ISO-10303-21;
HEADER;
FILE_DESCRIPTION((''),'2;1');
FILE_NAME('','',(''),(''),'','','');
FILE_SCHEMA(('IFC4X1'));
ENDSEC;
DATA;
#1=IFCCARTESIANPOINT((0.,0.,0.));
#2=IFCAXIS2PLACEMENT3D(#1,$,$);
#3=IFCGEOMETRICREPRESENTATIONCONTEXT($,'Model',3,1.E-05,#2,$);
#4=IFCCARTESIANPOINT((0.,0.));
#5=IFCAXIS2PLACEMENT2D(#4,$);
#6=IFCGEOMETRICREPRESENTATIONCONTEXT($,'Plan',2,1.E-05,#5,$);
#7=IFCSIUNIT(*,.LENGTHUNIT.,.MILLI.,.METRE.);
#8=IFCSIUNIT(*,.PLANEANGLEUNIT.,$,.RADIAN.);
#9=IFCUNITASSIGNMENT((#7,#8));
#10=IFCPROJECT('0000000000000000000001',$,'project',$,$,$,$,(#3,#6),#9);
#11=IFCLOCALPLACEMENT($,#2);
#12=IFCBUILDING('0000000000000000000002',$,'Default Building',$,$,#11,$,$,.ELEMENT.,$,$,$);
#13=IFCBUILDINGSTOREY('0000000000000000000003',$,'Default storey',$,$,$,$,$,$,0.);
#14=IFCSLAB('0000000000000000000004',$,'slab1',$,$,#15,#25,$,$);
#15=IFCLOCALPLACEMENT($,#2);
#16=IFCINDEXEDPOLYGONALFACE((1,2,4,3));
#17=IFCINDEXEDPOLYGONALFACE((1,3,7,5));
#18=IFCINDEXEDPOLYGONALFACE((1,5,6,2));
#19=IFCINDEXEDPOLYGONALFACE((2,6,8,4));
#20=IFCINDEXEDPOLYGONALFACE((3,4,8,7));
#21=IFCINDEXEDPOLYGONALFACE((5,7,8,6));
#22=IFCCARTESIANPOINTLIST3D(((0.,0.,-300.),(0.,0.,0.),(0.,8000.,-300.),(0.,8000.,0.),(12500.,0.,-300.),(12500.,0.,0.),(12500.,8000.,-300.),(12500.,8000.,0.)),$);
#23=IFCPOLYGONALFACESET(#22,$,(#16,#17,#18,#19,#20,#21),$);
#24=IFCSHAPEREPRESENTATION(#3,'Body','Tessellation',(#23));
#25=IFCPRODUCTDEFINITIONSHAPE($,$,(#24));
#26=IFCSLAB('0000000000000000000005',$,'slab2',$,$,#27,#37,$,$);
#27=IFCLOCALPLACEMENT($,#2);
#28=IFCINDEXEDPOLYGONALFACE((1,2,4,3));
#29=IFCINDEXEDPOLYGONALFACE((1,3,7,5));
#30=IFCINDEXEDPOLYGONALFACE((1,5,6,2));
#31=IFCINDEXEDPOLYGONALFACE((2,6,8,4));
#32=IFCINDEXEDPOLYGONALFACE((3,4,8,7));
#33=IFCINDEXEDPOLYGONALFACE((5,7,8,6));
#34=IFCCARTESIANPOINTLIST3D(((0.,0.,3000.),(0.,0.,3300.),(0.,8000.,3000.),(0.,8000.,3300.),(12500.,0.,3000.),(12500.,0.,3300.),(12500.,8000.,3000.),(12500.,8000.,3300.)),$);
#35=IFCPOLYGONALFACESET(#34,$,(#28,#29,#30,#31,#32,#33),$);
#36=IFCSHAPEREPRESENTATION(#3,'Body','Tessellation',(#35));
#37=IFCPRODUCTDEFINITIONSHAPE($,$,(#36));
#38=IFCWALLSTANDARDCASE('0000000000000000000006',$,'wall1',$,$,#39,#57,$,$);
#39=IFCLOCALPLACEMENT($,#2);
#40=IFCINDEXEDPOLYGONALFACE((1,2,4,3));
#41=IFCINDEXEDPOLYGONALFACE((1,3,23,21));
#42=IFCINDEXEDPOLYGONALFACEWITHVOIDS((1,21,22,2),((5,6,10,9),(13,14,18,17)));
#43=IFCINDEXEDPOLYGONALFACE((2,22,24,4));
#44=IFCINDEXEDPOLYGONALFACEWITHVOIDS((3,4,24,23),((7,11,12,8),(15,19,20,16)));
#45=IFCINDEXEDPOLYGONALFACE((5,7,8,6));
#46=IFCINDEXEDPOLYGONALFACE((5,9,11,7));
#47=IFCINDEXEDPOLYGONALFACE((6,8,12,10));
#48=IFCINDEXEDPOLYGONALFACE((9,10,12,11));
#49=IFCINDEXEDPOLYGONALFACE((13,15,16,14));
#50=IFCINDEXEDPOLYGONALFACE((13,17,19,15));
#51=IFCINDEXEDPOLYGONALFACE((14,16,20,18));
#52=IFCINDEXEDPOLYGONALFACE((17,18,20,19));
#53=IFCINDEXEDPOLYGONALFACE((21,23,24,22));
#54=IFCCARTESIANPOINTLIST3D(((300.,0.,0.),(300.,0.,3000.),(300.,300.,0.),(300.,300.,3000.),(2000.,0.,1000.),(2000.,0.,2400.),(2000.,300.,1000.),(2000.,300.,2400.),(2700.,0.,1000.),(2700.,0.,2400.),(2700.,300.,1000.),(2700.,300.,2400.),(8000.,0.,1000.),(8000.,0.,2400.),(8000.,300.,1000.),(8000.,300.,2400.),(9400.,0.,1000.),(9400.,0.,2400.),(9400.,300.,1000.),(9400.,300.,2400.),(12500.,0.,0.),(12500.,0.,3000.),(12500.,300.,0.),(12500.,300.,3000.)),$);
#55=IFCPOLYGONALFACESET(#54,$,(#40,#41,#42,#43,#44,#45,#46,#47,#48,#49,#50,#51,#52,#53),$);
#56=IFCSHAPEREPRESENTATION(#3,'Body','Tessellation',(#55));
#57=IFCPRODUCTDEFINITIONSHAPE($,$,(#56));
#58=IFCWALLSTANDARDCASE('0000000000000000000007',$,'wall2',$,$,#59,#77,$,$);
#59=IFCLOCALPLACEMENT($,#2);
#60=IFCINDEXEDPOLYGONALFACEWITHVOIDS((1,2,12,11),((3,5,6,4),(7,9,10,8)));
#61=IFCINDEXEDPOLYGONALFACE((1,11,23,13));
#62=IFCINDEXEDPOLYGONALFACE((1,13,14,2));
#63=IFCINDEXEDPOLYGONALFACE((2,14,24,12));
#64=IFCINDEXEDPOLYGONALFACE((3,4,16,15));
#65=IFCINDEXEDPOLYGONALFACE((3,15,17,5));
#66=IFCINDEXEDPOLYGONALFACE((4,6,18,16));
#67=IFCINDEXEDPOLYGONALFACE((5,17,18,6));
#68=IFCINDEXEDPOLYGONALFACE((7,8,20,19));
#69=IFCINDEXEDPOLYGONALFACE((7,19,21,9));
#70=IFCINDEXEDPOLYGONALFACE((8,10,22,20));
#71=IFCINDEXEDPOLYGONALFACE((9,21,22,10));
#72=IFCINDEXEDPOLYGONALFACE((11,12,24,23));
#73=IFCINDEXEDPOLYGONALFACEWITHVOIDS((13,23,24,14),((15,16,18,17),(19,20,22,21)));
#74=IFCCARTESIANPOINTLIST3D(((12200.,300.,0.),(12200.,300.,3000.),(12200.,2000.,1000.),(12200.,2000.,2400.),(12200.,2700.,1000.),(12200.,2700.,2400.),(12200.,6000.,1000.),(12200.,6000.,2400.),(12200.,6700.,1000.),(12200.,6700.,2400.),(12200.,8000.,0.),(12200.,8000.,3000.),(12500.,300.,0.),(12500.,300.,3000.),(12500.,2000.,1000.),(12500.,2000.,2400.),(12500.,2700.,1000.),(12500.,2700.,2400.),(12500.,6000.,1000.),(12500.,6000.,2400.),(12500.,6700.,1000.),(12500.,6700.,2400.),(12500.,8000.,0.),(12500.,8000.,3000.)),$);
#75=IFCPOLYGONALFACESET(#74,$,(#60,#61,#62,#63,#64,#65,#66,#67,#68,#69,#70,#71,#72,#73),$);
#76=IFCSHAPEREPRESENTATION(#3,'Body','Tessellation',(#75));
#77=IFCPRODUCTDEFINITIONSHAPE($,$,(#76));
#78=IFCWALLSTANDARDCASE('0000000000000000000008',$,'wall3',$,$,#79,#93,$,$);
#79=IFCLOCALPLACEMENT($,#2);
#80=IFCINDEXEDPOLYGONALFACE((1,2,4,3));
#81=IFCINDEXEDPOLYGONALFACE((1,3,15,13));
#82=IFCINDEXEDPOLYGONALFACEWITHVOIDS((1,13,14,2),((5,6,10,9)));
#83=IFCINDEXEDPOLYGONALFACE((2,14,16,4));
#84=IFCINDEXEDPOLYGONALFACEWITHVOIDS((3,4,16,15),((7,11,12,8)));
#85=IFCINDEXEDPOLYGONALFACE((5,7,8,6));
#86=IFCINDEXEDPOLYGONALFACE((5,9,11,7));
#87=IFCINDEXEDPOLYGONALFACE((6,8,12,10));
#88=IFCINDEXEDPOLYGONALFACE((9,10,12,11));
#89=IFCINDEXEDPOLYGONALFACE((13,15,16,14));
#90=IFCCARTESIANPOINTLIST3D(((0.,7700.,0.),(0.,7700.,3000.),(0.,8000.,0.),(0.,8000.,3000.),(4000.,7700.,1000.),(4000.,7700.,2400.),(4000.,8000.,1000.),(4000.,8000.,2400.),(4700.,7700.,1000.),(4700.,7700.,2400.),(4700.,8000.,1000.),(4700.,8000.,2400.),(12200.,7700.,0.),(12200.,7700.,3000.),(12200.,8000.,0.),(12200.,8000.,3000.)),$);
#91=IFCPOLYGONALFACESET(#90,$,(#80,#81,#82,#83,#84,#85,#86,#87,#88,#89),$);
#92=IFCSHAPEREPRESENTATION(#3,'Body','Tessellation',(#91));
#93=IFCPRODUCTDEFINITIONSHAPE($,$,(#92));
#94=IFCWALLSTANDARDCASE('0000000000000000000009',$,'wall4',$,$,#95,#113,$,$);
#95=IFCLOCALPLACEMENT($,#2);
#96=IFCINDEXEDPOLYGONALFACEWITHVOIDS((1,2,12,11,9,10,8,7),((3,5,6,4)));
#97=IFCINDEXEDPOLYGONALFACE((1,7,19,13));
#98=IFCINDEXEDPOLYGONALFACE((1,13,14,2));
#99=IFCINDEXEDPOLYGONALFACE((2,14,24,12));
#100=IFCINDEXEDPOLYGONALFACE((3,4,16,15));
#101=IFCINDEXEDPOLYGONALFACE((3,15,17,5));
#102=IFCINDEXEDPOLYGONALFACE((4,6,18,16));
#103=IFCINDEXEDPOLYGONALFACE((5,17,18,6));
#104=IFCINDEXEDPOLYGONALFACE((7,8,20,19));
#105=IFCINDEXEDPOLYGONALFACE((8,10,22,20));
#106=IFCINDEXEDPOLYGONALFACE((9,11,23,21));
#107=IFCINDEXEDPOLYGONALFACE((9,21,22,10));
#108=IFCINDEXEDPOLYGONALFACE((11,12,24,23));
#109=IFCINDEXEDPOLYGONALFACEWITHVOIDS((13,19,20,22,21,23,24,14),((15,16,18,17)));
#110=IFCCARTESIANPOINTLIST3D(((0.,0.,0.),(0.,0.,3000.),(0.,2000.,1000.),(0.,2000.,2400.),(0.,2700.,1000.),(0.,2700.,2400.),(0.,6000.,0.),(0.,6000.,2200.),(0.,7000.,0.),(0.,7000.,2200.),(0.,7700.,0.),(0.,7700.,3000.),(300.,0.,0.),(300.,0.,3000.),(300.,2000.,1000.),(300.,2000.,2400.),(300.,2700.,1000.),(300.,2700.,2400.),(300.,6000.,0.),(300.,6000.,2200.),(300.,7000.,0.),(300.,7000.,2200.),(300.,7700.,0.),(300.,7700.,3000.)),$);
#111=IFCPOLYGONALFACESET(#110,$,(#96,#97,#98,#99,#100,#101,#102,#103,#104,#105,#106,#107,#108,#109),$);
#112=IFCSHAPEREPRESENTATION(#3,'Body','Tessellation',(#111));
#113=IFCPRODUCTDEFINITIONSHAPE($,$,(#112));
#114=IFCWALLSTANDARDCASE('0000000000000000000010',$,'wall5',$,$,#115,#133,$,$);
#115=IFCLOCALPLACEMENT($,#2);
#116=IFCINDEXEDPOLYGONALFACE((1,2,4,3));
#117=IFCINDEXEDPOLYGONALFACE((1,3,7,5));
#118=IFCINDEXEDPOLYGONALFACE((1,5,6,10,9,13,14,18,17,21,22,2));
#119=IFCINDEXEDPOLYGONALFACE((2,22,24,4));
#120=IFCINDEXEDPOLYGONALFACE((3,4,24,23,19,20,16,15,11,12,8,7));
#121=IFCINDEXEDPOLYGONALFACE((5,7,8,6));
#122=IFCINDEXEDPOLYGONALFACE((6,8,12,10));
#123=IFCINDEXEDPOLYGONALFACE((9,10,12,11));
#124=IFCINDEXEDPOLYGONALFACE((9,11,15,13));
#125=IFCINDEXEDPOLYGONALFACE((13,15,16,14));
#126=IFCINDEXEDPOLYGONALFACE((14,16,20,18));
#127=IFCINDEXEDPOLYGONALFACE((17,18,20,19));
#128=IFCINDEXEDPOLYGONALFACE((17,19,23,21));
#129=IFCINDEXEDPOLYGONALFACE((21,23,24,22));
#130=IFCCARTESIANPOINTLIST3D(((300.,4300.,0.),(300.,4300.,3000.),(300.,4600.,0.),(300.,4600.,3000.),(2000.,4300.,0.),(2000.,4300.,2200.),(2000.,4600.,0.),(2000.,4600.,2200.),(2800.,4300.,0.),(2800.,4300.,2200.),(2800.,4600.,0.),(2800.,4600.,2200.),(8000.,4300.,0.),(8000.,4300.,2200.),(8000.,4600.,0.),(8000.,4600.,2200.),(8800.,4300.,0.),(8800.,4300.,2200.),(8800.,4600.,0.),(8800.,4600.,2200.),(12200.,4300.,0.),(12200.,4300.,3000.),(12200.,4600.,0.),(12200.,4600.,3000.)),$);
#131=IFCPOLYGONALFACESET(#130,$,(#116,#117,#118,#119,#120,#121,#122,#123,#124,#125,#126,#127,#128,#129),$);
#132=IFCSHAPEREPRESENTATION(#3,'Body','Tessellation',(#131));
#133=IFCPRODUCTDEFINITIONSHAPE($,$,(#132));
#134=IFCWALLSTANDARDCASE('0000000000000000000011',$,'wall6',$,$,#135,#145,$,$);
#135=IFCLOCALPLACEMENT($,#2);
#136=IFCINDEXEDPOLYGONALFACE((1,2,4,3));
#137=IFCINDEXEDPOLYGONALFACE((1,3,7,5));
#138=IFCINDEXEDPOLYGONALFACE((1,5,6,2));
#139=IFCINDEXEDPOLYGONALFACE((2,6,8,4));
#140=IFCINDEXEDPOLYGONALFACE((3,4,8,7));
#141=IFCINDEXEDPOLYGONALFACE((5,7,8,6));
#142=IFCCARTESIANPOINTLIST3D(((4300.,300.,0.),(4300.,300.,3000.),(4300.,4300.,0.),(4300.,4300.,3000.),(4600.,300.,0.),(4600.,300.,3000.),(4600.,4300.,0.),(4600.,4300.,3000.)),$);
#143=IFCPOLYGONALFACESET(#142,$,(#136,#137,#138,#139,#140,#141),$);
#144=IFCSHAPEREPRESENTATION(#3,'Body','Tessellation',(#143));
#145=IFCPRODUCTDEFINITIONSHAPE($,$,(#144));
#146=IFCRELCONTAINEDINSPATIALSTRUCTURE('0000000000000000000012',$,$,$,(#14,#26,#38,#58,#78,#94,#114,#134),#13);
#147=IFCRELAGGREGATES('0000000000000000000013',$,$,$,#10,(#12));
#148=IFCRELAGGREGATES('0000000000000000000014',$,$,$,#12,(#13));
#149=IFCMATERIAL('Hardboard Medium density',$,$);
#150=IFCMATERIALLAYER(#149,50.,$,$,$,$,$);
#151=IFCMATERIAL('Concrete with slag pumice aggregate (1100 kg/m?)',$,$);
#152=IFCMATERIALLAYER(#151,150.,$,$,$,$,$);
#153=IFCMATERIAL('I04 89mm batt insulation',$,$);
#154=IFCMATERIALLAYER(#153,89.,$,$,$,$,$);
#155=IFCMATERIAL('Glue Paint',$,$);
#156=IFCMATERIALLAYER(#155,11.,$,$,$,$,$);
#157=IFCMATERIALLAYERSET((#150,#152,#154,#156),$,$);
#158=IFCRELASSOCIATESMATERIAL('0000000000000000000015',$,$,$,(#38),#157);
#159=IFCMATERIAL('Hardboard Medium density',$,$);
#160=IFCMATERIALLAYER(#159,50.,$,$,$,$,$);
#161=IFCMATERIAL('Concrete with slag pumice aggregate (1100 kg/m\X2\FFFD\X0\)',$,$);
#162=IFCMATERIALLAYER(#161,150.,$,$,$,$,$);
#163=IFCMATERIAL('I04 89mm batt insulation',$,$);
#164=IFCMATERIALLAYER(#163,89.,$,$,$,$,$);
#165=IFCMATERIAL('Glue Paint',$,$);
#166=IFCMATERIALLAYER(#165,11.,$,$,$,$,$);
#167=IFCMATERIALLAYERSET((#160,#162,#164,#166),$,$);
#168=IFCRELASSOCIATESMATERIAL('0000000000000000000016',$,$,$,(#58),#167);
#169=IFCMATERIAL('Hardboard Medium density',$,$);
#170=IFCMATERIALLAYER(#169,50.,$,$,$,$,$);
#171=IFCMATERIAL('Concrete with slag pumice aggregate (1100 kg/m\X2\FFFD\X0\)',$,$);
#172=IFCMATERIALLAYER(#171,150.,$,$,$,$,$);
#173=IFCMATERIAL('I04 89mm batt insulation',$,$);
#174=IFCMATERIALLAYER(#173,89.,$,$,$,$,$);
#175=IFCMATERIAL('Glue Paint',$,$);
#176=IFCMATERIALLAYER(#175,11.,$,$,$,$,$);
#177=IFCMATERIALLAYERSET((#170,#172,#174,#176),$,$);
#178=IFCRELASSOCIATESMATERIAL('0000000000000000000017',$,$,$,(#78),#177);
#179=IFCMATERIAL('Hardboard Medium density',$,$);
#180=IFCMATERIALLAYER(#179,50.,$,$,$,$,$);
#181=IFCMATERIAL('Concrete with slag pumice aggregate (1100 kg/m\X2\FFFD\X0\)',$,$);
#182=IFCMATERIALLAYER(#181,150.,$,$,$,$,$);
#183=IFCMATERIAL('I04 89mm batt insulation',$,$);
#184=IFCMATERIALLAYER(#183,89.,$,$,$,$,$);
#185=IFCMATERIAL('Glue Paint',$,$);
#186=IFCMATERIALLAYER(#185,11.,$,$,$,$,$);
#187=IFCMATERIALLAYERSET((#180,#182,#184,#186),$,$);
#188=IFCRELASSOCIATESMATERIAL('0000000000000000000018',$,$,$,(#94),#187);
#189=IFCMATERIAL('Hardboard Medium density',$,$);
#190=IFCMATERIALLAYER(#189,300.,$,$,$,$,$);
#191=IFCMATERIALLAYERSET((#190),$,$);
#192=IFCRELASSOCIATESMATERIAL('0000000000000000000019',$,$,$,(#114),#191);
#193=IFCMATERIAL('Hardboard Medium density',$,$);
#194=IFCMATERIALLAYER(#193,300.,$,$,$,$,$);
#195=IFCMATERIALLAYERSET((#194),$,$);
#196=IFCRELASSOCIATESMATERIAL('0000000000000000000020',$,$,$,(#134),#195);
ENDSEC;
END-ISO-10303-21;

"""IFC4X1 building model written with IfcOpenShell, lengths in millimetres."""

from ifc_helpers import new_model, si_unit, frame, origin, origin_2d, place, context, project, spatial, polyline, outline, extrude, material, layer, layer_set, layer_usage, element, save


model = new_model("IFC4X1")

# Units and contexts
model_context = context("Model", 3, precision=1e-05, world=origin())
plan_context = context("Plan", 2, precision=1e-05, world=origin_2d())
ifc_project = project(units=[si_unit("LENGTHUNIT", "METRE", prefix="MILLI"), si_unit("PLANEANGLEUNIT", "RADIAN")], contexts=[model_context, plan_context])

# Building, storey
building_placement = place(None, origin())
building = spatial("IfcBuilding", under=ifc_project, at=building_placement, Name="Default Building", CompositionType="ELEMENT")
storey = spatial("IfcBuildingStorey", under=building, Name="Default storey", Elevation=0.0)

# Slabs
slab_1_placement = place(None, frame((0.0, 0.0, -300.0), z_axis=(0.0, 0.0, 1.0)))
element("IfcSlab", 1, at=slab_1_placement, inside=storey, Name="slab1", context=model_context, shape_type="SweptSolid", body=[
    extrude(outline(polyline([(0.0, 0.0), (12500.0, 0.0), (12500.0, 8000.0), (0.0, 8000.0), (0.0, 0.0)])), origin(), (0.0, 0.0, 1.0), 300.0),
])
slab_2_placement = place(None, frame((0.0, 0.0, 3000.0), z_axis=(0.0, 0.0, 1.0)))
element("IfcSlab", 2, at=slab_2_placement, inside=storey, Name="slab2", context=model_context, shape_type="SweptSolid", body=[
    extrude(outline(polyline([(0.0, 0.0), (0.0, 8000.0), (12500.0, 8000.0), (12500.0, 0.0), (0.0, 0.0)])), origin(), (0.0, 0.0, 1.0), 300.0),
])

# Walls, openings
ifc_material_1 = material(Name="Hardboard Medium density")
ifc_layer_1 = layer(ifc_material_1, 50.0)
ifc_material_2 = material(Name="Concrete with slag pumice aggregate (1100 kg/m?)")
ifc_layer_2 = layer(ifc_material_2, 150.0)
ifc_material_3 = material(Name="I04 89mm batt insulation")
ifc_layer_3 = layer(ifc_material_3, 89.0)
ifc_material_4 = material(Name="Glue Paint")
ifc_layer_4 = layer(ifc_material_4, 11.0)
ifc_layer_set_1 = layer_set([ifc_layer_1, ifc_layer_2, ifc_layer_3, ifc_layer_4])
ifc_layer_usage_1 = layer_usage(ifc_layer_set_1, "AXIS2", "NEGATIVE", 150.0)
wall_1_placement = place(None, frame((0.0, 0.0, 0.0), z_axis=(0.0, 0.0, 1.0)))
wall_1 = element("IfcWallStandardCase", 3, at=wall_1_placement, inside=storey, material=ifc_layer_usage_1, Name="wall1", context=model_context, shape_type="SweptSolid", body=[
    extrude(outline(polyline([(300.0, 0.0), (12500.0, 0.0), (12500.0, 300.0), (300.0, 300.0), (300.0, 0.0)])), origin(), (0.0, 0.0, 1.0), 3000.0),
])
opening_1_placement = place(None, frame((0.0, 0.0, 1000.0), z_axis=(0.0, 0.0, 1.0)))
element("IfcOpeningElement", 4, at=opening_1_placement, inside=storey, cuts=wall_1, context=model_context, shape_type="SweptSolid", body=[
    extrude(outline(polyline([(8000.0, 0.0), (9400.0, 0.0), (9400.0, 300.0), (8000.0, 300.0), (8000.0, 0.0)])), origin(), (0.0, 0.0, 1.0), 1400.0),
])
opening_2_placement = place(None, frame((0.0, 0.0, 1000.0), z_axis=(0.0, 0.0, 1.0)))
element("IfcOpeningElement", 5, at=opening_2_placement, inside=storey, cuts=wall_1, context=model_context, shape_type="SweptSolid", body=[
    extrude(outline(polyline([(2000.0, 0.0), (2700.0, 0.0), (2700.0, 300.0), (2000.0, 300.0), (2000.0, 0.0)])), origin(), (0.0, 0.0, 1.0), 1400.0),
])
ifc_material_5 = material(Name="Hardboard Medium density")
ifc_layer_5 = layer(ifc_material_5, 50.0)
ifc_material_6 = material(Name="Concrete with slag pumice aggregate (1100 kg/m�)")
ifc_layer_6 = layer(ifc_material_6, 150.0)
ifc_material_7 = material(Name="I04 89mm batt insulation")
ifc_layer_7 = layer(ifc_material_7, 89.0)
ifc_material_8 = material(Name="Glue Paint")
ifc_layer_8 = layer(ifc_material_8, 11.0)
ifc_layer_set_2 = layer_set([ifc_layer_5, ifc_layer_6, ifc_layer_7, ifc_layer_8])
ifc_layer_usage_2 = layer_usage(ifc_layer_set_2, "AXIS2", "NEGATIVE", 150.0)
wall_2_placement = place(None, frame((0.0, 0.0, 0.0), z_axis=(0.0, 0.0, 1.0)))
wall_2 = element("IfcWallStandardCase", 6, at=wall_2_placement, inside=storey, material=ifc_layer_usage_2, Name="wall2", context=model_context, shape_type="SweptSolid", body=[
    extrude(outline(polyline([(12500.0, 300.0), (12500.0, 8000.0), (12200.0, 8000.0), (12200.0, 300.0), (12500.0, 300.0)])), origin(), (0.0, 0.0, 1.0), 3000.0),
])
opening_3_placement = place(None, frame((0.0, 0.0, 1000.0), z_axis=(0.0, 0.0, 1.0)))
element("IfcOpeningElement", 7, at=opening_3_placement, inside=storey, cuts=wall_2, context=model_context, shape_type="SweptSolid", body=[
    extrude(outline(polyline([(12500.0, 6000.0), (12500.0, 6700.0), (12200.0, 6700.0), (12200.0, 6000.0), (12500.0, 6000.0)])), origin(), (0.0, 0.0, 1.0), 1400.0),
])
opening_4_placement = place(None, frame((0.0, 0.0, 1000.0), z_axis=(0.0, 0.0, 1.0)))
element("IfcOpeningElement", 8, at=opening_4_placement, inside=storey, cuts=wall_2, context=model_context, shape_type="SweptSolid", body=[
    extrude(outline(polyline([(12500.0, 2000.0), (12500.0, 2700.0), (12200.0, 2700.0), (12200.0, 2000.0), (12500.0, 2000.0)])), origin(), (0.0, 0.0, 1.0), 1400.0),
])

# Wall, opening
ifc_material_9 = material(Name="Hardboard Medium density")
ifc_layer_9 = layer(ifc_material_9, 50.0)
ifc_material_10 = material(Name="Concrete with slag pumice aggregate (1100 kg/m�)")
ifc_layer_10 = layer(ifc_material_10, 150.0)
ifc_material_11 = material(Name="I04 89mm batt insulation")
ifc_layer_11 = layer(ifc_material_11, 89.0)
ifc_material_12 = material(Name="Glue Paint")
ifc_layer_12 = layer(ifc_material_12, 11.0)
ifc_layer_set_3 = layer_set([ifc_layer_9, ifc_layer_10, ifc_layer_11, ifc_layer_12])
ifc_layer_usage_3 = layer_usage(ifc_layer_set_3, "AXIS2", "NEGATIVE", 150.0)
wall_3_placement = place(None, frame((0.0, 0.0, 0.0), z_axis=(0.0, 0.0, 1.0)))
wall_3 = element("IfcWallStandardCase", 9, at=wall_3_placement, inside=storey, material=ifc_layer_usage_3, Name="wall3", context=model_context, shape_type="SweptSolid", body=[
    extrude(outline(polyline([(12200.0, 8000.0), (0.0, 8000.0), (0.0, 7700.0), (12200.0, 7700.0), (12200.0, 8000.0)])), origin(), (0.0, 0.0, 1.0), 3000.0),
])
opening_5_placement = place(None, frame((0.0, 0.0, 1000.0), z_axis=(0.0, 0.0, 1.0)))
element("IfcOpeningElement", 10, at=opening_5_placement, inside=storey, cuts=wall_3, context=model_context, shape_type="SweptSolid", body=[
    extrude(outline(polyline([(4000.0, 8000.0), (4700.0, 8000.0), (4700.0, 7700.0), (4000.0, 7700.0), (4000.0, 8000.0)])), origin(), (0.0, 0.0, 1.0), 1400.0),
])

# Walls, openings
ifc_material_13 = material(Name="Hardboard Medium density")
ifc_layer_13 = layer(ifc_material_13, 50.0)
ifc_material_14 = material(Name="Concrete with slag pumice aggregate (1100 kg/m�)")
ifc_layer_14 = layer(ifc_material_14, 150.0)
ifc_material_15 = material(Name="I04 89mm batt insulation")
ifc_layer_15 = layer(ifc_material_15, 89.0)
ifc_material_16 = material(Name="Glue Paint")
ifc_layer_16 = layer(ifc_material_16, 11.0)
ifc_layer_set_4 = layer_set([ifc_layer_13, ifc_layer_14, ifc_layer_15, ifc_layer_16])
ifc_layer_usage_4 = layer_usage(ifc_layer_set_4, "AXIS2", "NEGATIVE", 150.0)
wall_4_placement = place(None, frame((0.0, 0.0, 0.0), z_axis=(0.0, 0.0, 1.0)))
wall_4 = element("IfcWallStandardCase", 11, at=wall_4_placement, inside=storey, material=ifc_layer_usage_4, Name="wall4", context=model_context, shape_type="SweptSolid", body=[
    extrude(outline(polyline([(0.0, 7700.0), (0.0, 0.0), (300.0, 0.0), (300.0, 7700.0), (0.0, 7700.0)])), origin(), (0.0, 0.0, 1.0), 3000.0),
])
opening_6_placement = place(None, frame((0.0, 0.0, 0.0), z_axis=(0.0, 0.0, 1.0)))
element("IfcOpeningElement", 12, at=opening_6_placement, inside=storey, cuts=wall_4, context=model_context, shape_type="SweptSolid", body=[
    extrude(outline(polyline([(0.0, 6000.0), (0.0, 7000.0), (300.0, 7000.0), (300.0, 6000.0), (0.0, 6000.0)])), origin(), (0.0, 0.0, 1.0), 2200.0),
])
opening_7_placement = place(None, frame((0.0, 0.0, 1000.0), z_axis=(0.0, 0.0, 1.0)))
element("IfcOpeningElement", 13, at=opening_7_placement, inside=storey, cuts=wall_4, context=model_context, shape_type="SweptSolid", body=[
    extrude(outline(polyline([(0.0, 2000.0), (0.0, 2700.0), (300.0, 2700.0), (300.0, 2000.0), (0.0, 2000.0)])), origin(), (0.0, 0.0, 1.0), 1400.0),
])
ifc_material_17 = material(Name="Hardboard Medium density")
ifc_layer_17 = layer(ifc_material_17, 300.0)
ifc_layer_set_5 = layer_set([ifc_layer_17])
ifc_layer_usage_5 = layer_usage(ifc_layer_set_5, "AXIS2", "NEGATIVE", 150.0)
wall_5_placement = place(None, frame((0.0, 0.0, 0.0), z_axis=(0.0, 0.0, 1.0)))
wall_5 = element("IfcWallStandardCase", 14, at=wall_5_placement, inside=storey, material=ifc_layer_usage_5, Name="wall5", context=model_context, shape_type="SweptSolid", body=[
    extrude(outline(polyline([(12200.0, 4600.0), (300.0, 4600.0), (300.0, 4300.0), (12200.0, 4300.0), (12200.0, 4600.0)])), origin(), (0.0, 0.0, 1.0), 3000.0),
])
opening_8_placement = place(None, frame((0.0, 0.0, 0.0), z_axis=(0.0, 0.0, 1.0)))
element("IfcOpeningElement", 15, at=opening_8_placement, inside=storey, cuts=wall_5, context=model_context, shape_type="SweptSolid", body=[
    extrude(outline(polyline([(2000.0, 4600.0), (2800.0, 4600.0), (2800.0, 4300.0), (2000.0, 4300.0), (2000.0, 4600.0)])), origin(), (0.0, 0.0, 1.0), 2200.0),
])
opening_9_placement = place(None, frame((0.0, 0.0, 0.0), z_axis=(0.0, 0.0, 1.0)))
element("IfcOpeningElement", 16, at=opening_9_placement, inside=storey, cuts=wall_5, context=model_context, shape_type="SweptSolid", body=[
    extrude(outline(polyline([(8000.0, 4600.0), (8800.0, 4600.0), (8800.0, 4300.0), (8000.0, 4300.0), (8000.0, 4600.0)])), origin(), (0.0, 0.0, 1.0), 2200.0),
])

# Wall
ifc_material_18 = material(Name="Hardboard Medium density")
ifc_layer_18 = layer(ifc_material_18, 300.0)
ifc_layer_set_6 = layer_set([ifc_layer_18])
ifc_layer_usage_6 = layer_usage(ifc_layer_set_6, "AXIS2", "NEGATIVE", 150.0)
wall_6_placement = place(None, frame((0.0, 0.0, 0.0), z_axis=(0.0, 0.0, 1.0)))
element("IfcWallStandardCase", 17, at=wall_6_placement, inside=storey, material=ifc_layer_usage_6, Name="wall6", context=model_context, shape_type="SweptSolid", body=[
    extrude(outline(polyline([(4300.0, 4300.0), (4300.0, 300.0), (4600.0, 300.0), (4600.0, 4300.0), (4300.0, 4300.0)])), origin(), (0.0, 0.0, 1.0), 3000.0),
])

save(model, "model.ifc")
